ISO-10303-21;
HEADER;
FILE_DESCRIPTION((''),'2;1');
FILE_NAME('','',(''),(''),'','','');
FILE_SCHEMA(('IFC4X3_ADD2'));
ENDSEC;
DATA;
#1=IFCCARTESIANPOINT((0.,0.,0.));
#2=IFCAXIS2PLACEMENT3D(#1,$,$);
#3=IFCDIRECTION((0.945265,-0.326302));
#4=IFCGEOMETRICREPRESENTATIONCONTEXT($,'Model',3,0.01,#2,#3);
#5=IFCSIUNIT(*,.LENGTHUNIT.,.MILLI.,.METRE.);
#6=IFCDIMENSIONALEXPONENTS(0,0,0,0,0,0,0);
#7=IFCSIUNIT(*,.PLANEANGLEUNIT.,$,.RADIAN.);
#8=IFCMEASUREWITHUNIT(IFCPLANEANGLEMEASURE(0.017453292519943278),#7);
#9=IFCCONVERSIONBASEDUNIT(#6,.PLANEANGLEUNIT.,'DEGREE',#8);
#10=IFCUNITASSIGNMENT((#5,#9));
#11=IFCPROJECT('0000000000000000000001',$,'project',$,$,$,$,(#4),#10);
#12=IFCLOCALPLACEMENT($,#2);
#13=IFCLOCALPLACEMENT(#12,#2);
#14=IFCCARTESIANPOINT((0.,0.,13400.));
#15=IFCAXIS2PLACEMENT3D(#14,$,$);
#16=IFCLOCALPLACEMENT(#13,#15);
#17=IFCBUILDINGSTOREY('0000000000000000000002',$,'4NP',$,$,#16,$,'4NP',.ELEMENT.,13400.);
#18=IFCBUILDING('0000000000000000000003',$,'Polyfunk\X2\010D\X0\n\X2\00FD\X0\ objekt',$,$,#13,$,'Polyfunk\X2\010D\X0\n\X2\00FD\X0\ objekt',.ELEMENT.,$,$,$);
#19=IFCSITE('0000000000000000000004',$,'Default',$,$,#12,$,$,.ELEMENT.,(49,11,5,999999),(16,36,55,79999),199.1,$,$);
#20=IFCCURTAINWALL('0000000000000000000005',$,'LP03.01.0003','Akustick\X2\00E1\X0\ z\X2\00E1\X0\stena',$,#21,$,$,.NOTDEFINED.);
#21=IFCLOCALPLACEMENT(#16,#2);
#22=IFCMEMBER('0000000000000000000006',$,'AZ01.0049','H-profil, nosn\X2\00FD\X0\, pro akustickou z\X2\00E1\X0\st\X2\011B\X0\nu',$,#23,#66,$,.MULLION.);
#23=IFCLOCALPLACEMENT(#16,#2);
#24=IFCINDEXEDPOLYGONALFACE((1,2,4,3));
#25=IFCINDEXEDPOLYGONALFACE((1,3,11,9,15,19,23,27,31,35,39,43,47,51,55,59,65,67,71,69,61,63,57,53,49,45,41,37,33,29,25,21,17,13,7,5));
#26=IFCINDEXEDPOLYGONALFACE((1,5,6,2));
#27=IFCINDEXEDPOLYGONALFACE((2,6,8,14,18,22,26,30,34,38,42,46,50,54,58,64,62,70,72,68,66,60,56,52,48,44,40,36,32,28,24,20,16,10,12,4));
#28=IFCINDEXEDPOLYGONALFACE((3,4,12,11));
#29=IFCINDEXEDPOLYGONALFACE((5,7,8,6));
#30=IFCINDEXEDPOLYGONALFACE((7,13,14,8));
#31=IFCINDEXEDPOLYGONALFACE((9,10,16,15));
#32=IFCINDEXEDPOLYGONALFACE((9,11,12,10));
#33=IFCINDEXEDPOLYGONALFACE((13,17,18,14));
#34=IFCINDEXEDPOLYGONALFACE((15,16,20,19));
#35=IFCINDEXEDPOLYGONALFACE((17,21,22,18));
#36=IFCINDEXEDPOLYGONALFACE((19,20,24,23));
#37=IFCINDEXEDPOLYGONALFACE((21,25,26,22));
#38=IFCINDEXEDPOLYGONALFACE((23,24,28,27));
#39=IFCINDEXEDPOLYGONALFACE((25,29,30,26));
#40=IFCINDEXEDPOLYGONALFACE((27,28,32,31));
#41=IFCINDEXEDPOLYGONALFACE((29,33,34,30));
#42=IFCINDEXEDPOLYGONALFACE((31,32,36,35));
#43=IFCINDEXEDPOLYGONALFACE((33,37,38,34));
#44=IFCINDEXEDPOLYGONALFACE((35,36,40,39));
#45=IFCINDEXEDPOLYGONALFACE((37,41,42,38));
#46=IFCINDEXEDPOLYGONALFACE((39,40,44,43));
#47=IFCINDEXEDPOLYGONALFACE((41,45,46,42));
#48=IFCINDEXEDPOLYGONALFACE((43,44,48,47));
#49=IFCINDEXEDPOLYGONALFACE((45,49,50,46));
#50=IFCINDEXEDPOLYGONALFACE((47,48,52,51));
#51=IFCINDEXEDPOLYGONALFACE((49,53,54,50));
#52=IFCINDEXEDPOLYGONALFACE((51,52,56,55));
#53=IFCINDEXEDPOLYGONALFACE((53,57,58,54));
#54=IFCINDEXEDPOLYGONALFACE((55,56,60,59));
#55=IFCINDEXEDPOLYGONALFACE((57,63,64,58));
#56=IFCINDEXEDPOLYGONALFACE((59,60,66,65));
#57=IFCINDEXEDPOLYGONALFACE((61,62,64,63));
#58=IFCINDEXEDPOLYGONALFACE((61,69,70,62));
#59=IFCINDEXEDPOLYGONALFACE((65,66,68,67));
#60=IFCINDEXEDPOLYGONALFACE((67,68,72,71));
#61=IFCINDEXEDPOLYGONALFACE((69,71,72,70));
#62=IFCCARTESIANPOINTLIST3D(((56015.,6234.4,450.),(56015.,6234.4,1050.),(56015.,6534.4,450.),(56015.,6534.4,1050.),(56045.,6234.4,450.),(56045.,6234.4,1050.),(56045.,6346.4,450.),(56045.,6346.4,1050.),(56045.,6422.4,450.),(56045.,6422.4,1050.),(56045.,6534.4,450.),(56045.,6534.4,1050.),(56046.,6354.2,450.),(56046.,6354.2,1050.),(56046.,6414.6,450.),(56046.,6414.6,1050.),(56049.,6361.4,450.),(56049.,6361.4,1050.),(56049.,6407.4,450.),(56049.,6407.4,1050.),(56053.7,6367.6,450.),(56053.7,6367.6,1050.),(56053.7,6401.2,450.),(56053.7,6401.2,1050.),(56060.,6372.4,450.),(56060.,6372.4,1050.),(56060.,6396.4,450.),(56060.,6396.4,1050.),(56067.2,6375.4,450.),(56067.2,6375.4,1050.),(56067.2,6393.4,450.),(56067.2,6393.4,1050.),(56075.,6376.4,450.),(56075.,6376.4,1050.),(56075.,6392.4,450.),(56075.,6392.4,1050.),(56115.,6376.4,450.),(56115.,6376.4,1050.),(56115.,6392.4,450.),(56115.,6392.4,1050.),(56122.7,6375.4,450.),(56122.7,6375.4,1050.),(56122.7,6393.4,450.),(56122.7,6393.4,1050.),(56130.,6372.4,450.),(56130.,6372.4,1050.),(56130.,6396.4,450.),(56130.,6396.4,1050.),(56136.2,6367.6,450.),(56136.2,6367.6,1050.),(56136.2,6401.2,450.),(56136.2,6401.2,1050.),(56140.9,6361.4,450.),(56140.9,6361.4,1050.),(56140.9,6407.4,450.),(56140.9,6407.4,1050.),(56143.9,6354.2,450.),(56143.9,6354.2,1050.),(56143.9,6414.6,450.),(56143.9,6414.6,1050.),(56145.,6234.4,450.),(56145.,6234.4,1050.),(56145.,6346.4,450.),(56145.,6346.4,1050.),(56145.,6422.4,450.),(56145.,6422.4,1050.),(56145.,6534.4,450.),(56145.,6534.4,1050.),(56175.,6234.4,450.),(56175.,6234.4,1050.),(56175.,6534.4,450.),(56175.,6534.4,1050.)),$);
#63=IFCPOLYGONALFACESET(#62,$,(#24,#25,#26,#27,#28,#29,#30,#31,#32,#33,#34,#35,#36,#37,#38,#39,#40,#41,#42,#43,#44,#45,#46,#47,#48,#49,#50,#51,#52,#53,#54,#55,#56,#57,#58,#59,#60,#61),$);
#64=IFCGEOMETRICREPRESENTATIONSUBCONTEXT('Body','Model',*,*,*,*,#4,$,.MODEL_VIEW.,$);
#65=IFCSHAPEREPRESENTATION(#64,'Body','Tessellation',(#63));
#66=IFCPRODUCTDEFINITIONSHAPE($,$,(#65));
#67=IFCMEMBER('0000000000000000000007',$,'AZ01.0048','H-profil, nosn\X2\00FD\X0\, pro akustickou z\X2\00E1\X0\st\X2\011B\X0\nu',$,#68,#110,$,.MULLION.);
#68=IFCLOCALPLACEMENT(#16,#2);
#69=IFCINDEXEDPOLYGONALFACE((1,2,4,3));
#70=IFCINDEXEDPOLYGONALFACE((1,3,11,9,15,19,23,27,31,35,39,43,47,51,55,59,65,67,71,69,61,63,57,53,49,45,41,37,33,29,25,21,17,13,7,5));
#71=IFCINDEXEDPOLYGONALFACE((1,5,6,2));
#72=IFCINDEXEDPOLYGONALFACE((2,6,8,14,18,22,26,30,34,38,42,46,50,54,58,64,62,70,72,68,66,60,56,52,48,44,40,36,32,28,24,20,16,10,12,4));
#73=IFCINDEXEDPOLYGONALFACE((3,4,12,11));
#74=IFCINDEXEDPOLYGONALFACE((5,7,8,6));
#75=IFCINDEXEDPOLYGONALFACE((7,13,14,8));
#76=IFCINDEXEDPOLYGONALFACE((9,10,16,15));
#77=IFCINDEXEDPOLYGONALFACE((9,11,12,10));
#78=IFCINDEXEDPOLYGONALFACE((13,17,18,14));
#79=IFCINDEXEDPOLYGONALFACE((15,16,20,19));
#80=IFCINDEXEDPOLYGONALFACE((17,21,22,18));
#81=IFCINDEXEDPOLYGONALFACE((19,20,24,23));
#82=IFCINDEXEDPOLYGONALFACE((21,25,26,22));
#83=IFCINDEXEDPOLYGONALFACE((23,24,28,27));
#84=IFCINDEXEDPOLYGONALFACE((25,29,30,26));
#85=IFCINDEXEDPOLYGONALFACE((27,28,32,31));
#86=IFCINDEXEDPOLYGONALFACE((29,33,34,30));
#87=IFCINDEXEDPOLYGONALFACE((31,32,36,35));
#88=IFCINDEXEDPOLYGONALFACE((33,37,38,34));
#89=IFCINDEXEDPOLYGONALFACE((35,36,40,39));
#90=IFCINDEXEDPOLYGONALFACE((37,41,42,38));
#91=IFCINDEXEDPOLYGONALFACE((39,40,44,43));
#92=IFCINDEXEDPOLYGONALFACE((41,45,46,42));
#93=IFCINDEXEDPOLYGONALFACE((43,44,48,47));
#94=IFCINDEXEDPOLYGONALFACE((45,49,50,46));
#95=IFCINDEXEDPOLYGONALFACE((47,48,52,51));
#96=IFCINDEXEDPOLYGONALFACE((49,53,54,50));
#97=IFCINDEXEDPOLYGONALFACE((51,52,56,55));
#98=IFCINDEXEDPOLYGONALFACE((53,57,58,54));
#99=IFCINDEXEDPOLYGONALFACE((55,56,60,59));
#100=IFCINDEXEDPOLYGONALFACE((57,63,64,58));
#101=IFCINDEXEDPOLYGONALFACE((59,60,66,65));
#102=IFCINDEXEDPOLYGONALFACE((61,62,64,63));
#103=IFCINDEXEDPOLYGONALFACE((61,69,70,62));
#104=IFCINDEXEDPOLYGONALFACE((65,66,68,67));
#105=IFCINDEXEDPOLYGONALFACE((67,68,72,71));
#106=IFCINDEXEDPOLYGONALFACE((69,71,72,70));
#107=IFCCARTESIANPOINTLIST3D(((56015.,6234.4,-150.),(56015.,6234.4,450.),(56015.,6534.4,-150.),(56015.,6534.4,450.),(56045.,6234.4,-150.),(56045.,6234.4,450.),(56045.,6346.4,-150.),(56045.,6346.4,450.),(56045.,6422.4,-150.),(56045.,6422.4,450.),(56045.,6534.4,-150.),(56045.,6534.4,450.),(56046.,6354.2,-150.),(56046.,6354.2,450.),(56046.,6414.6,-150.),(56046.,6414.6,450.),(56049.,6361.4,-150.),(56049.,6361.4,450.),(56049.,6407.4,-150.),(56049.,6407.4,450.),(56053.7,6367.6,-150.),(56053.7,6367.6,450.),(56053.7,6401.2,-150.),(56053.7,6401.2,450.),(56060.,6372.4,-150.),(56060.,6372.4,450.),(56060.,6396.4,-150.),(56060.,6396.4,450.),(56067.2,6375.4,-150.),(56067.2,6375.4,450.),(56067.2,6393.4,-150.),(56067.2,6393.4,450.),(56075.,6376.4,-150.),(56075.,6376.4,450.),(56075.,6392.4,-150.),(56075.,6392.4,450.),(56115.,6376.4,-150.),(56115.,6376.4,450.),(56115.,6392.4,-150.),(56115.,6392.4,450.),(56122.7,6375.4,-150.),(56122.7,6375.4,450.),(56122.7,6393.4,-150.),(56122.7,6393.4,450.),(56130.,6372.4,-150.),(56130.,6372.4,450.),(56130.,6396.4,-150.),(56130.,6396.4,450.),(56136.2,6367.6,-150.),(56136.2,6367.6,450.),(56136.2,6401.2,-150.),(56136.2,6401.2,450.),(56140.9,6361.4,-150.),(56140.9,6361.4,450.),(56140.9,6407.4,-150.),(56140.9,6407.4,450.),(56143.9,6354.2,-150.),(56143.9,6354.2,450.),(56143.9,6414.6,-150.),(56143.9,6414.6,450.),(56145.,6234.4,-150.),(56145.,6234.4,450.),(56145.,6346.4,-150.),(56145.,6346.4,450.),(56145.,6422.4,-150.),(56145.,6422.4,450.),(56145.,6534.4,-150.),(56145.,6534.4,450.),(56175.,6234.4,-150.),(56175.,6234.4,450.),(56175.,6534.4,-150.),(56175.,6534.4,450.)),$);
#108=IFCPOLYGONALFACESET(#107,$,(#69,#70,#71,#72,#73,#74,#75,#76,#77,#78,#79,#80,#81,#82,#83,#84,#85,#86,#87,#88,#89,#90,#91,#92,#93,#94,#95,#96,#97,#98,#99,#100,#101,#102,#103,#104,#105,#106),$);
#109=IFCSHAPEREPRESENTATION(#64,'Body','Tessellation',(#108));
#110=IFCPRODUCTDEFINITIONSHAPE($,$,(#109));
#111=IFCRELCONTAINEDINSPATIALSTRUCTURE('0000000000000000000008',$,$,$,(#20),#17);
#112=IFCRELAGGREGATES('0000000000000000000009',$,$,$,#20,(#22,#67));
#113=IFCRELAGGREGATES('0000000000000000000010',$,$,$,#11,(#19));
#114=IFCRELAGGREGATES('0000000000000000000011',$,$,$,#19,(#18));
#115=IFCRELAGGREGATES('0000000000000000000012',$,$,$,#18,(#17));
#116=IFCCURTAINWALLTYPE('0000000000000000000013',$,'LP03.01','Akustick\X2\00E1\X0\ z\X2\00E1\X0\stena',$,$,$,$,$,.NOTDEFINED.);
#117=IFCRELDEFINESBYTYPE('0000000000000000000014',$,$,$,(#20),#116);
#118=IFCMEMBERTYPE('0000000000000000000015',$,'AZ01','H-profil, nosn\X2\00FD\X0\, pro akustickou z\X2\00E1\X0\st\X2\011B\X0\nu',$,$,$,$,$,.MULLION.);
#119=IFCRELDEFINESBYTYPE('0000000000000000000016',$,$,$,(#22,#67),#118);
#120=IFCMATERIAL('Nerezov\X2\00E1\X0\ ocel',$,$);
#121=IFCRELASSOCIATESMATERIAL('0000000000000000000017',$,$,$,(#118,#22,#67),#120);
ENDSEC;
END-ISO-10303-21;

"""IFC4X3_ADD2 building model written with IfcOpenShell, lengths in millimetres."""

from ifc_helpers import new_model, entity, si_unit, converted_unit, direction, frame, frame_2d, origin, place, context, subcontext, project, spatial, polyline, circle_curve, parameter, trimmed, segment, composite_curve, outline, extrude, source, transform, mapped, material, material_profile, profile_set, profile_usage, type_object, element, aggregate, save


model = new_model("IFC4X3_ADD2")

# Units and contexts
model_context = context("Model", 3, precision=0.01, world=origin(), true_north=direction((0.945265, -0.326302)))
body_context = subcontext(model_context, "Body", "Model", "MODEL_VIEW")
ifc_project = project(units=[si_unit("LENGTHUNIT", "METRE", prefix="MILLI"), converted_unit("PLANEANGLEUNIT", "DEGREE", entity("IfcPlaneAngleMeasure", 0.017453292519943278), si_unit("PLANEANGLEUNIT", "RADIAN"), dimensions=[0, 0, 0, 0, 0, 0, 0])], contexts=[model_context])

# Site, building, storey
site_placement = place(None, origin())
site = spatial("IfcSite", under=ifc_project, at=site_placement, Name="Default", CompositionType="ELEMENT", RefLatitude=(49, 11, 5, 999999), RefLongitude=(16, 36, 55, 79999), RefElevation=199.1)
building_placement = place(site_placement, origin())
building = spatial("IfcBuilding", under=site, at=building_placement, Name="Polyfunkčný objekt", LongName="Polyfunkčný objekt", CompositionType="ELEMENT")
storey_placement = place(building_placement, frame((0.0, 0.0, 13400.0)))
storey = spatial("IfcBuildingStorey", under=building, at=storey_placement, Name="4NP", LongName="4NP", CompositionType="ELEMENT", Elevation=13400.0)

# Shared definitions
curtain_wall_type = type_object("IfcCurtainWallType", Name="LP03.01", Description="Akustická zástena", PredefinedType="NOTDEFINED")
ifc_material_1 = material(Name="Nerezová ocel")
ifc_material_profile = material_profile(ifc_material_1, outline(composite_curve([segment(polyline([(50.0, -150.0), (80.0, -150.0)]), True, "CONTINUOUS"), segment(polyline([(80.0, -150.0), (80.0, 150.0)]), True, "CONTINUOUS"), segment(polyline([(80.0, 150.0), (50.0, 150.0)]), True, "CONTINUOUS"), segment(polyline([(50.0, 150.0), (50.0, 38.0)]), True, "CONTINUOUS"), segment(trimmed(circle_curve(frame_2d((20.0, 38.0), x_axis=(0.0, 1.0)), 30.0), [parameter(180.0)], [parameter(270.0)], True, "PARAMETER"), False, "CONTINUOUS"), segment(polyline([(20.0, 8.0), (-20.0, 8.0)]), True, "CONTINUOUS"), segment(trimmed(circle_curve(frame_2d((-20.0, 38.0), x_axis=(0.0, 1.0)), 30.0), [parameter(90.0)], [parameter(180.0)], True, "PARAMETER"), False, "CONTINUOUS"), segment(polyline([(-50.0, 38.0), (-50.0, 150.0)]), True, "CONTINUOUS"), segment(polyline([(-50.0, 150.0), (-80.0, 150.0)]), True, "CONTINUOUS"), segment(polyline([(-80.0, 150.0), (-80.0, -150.0)]), True, "CONTINUOUS"), segment(polyline([(-80.0, -150.0), (-50.0, -150.0)]), True, "CONTINUOUS"), segment(polyline([(-50.0, -150.0), (-50.0, -38.0)]), True, "CONTINUOUS"), segment(trimmed(circle_curve(frame_2d((-20.0, -38.0), x_axis=(0.0, 1.0)), 30.0), [parameter(0.0)], [parameter(90.0)], True, "PARAMETER"), False, "CONTINUOUS"), segment(polyline([(-20.0, -8.0), (20.0, -8.0)]), True, "CONTINUOUS"), segment(trimmed(circle_curve(frame_2d((20.0, -38.0), x_axis=(0.0, 1.0)), 30.0), [parameter(270.0)], [parameter(0.0)], True, "PARAMETER"), False, "CONTINUOUS"), segment(polyline([(50.0, -38.0), (50.0, -150.0)]), True, "CONTINUOUS")], self_intersect=False)), Name="Profil zástena")
ifc_profile_set = profile_set([ifc_material_profile], Name="Profil zástena")
ifc_profile_usage = profile_usage(ifc_profile_set)
member_type = type_object("IfcMemberType", Name="AZ01", Description="H-profil, nosný, pro akustickou zástěnu", PredefinedType="MULLION", material=ifc_profile_set)

# Curtain wall, members
curtain_wall_1_placement = place(storey_placement, frame((0.0, 0.0, -13400.0)))
curtain_wall_1 = element("IfcCurtainWall", 1, at=curtain_wall_1_placement, inside=storey, type_object=curtain_wall_type, Name="LP03.01.0003", Description="Akustická zástena", PredefinedType="NOTDEFINED")
shared_shape_1 = source(origin(), body_context, "Body", "SweptSolid", [
    extrude(outline(composite_curve([segment(polyline([(-150.0, -50.0), (-150.0, -80.0)]), True, "CONTINUOUS"), segment(polyline([(-150.0, -80.0), (150.0, -80.0)]), True, "CONTINUOUS"), segment(polyline([(150.0, -80.0), (150.0, -50.0)]), True, "CONTINUOUS"), segment(polyline([(150.0, -50.0), (38.0, -50.0)]), True, "CONTINUOUS"), segment(trimmed(circle_curve(frame_2d((38.0, -20.0), x_axis=(1.0, 0.0)), 30.0), [parameter(180.0)], [parameter(270.0)], True, "PARAMETER"), False, "CONTINUOUS"), segment(polyline([(8.0, -20.0), (8.0, 20.0)]), True, "CONTINUOUS"), segment(trimmed(circle_curve(frame_2d((38.0, 20.0), x_axis=(1.0, 0.0)), 30.0), [parameter(90.0)], [parameter(180.0)], True, "PARAMETER"), False, "CONTINUOUS"), segment(polyline([(38.0, 50.0), (150.0, 50.0)]), True, "CONTINUOUS"), segment(polyline([(150.0, 50.0), (150.0, 80.0)]), True, "CONTINUOUS"), segment(polyline([(150.0, 80.0), (-150.0, 80.0)]), True, "CONTINUOUS"), segment(polyline([(-150.0, 80.0), (-150.0, 50.0)]), True, "CONTINUOUS"), segment(polyline([(-150.0, 50.0), (-38.0, 50.0)]), True, "CONTINUOUS"), segment(trimmed(circle_curve(frame_2d((-38.0, 20.0), x_axis=(1.0, 0.0)), 30.0), [parameter(0.0)], [parameter(90.0)], True, "PARAMETER"), False, "CONTINUOUS"), segment(polyline([(-8.0, 20.0), (-8.0, -20.0)]), True, "CONTINUOUS"), segment(trimmed(circle_curve(frame_2d((-38.0, -20.0), x_axis=(1.0, 0.0)), 30.0), [parameter(270.0)], [parameter(0.0)], True, "PARAMETER"), False, "CONTINUOUS"), segment(polyline([(-38.0, -50.0), (-150.0, -50.0)]), True, "CONTINUOUS")], self_intersect=False)), frame((-150.0, 0.0, -600.0), z_axis=(0.0, 0.0, -1.0), x_axis=(1.0, 0.0, 0.0)), (0.0, 0.0, -1.0), 600.0),
])
member_1_placement = place(curtain_wall_1_placement, frame((56095.0, 6534.4, 13850.0), z_axis=(0.0, 0.0, -1.0), x_axis=(0.0, 1.0, 0.0)))
member_1 = element("IfcMember", 2, at=member_1_placement, type_object=member_type, material=ifc_profile_usage, Name="AZ01.0049", Description="H-profil, nosný, pro akustickou zástěnu", PredefinedType="MULLION", context=body_context, shape_type="MappedRepresentation", body=[
    mapped(shared_shape_1, transform((0.0, 0.0, 0.0), scale=1.0)),
])
shared_shape_2 = source(origin(), body_context, "Body", "SweptSolid", [
    extrude(outline(composite_curve([segment(polyline([(-150.0, -50.0), (-150.0, -80.0)]), True, "CONTINUOUS"), segment(polyline([(-150.0, -80.0), (150.0, -80.0)]), True, "CONTINUOUS"), segment(polyline([(150.0, -80.0), (150.0, -50.0)]), True, "CONTINUOUS"), segment(polyline([(150.0, -50.0), (38.0, -50.0)]), True, "CONTINUOUS"), segment(trimmed(circle_curve(frame_2d((38.0, -20.0), x_axis=(1.0, 0.0)), 30.0), [parameter(180.0)], [parameter(270.0)], True, "PARAMETER"), False, "CONTINUOUS"), segment(polyline([(8.0, -20.0), (8.0, 20.0)]), True, "CONTINUOUS"), segment(trimmed(circle_curve(frame_2d((38.0, 20.0), x_axis=(1.0, 0.0)), 30.0), [parameter(90.0)], [parameter(180.0)], True, "PARAMETER"), False, "CONTINUOUS"), segment(polyline([(38.0, 50.0), (150.0, 50.0)]), True, "CONTINUOUS"), segment(polyline([(150.0, 50.0), (150.0, 80.0)]), True, "CONTINUOUS"), segment(polyline([(150.0, 80.0), (-150.0, 80.0)]), True, "CONTINUOUS"), segment(polyline([(-150.0, 80.0), (-150.0, 50.0)]), True, "CONTINUOUS"), segment(polyline([(-150.0, 50.0), (-38.0, 50.0)]), True, "CONTINUOUS"), segment(trimmed(circle_curve(frame_2d((-38.0, 20.0), x_axis=(1.0, 0.0)), 30.0), [parameter(0.0)], [parameter(90.0)], True, "PARAMETER"), False, "CONTINUOUS"), segment(polyline([(-8.0, 20.0), (-8.0, -20.0)]), True, "CONTINUOUS"), segment(trimmed(circle_curve(frame_2d((-38.0, -20.0), x_axis=(1.0, 0.0)), 30.0), [parameter(270.0)], [parameter(0.0)], True, "PARAMETER"), False, "CONTINUOUS"), segment(polyline([(-38.0, -50.0), (-150.0, -50.0)]), True, "CONTINUOUS")], self_intersect=False)), frame((-150.0, 0.0, -600.0), z_axis=(0.0, 0.0, -1.0), x_axis=(1.0, 0.0, 0.0)), (0.0, 0.0, -1.0), 600.0),
])
member_2_placement = place(curtain_wall_1_placement, frame((56095.0, 6534.4, 13250.0), z_axis=(0.0, 0.0, -1.0), x_axis=(0.0, 1.0, 0.0)))
member_2 = element("IfcMember", 3, at=member_2_placement, type_object=member_type, material=ifc_profile_usage, Name="AZ01.0048", Description="H-profil, nosný, pro akustickou zástěnu", PredefinedType="MULLION", context=body_context, shape_type="MappedRepresentation", body=[
    mapped(shared_shape_2, transform((0.0, 0.0, 0.0), scale=1.0)),
])
aggregate(curtain_wall_1, [member_1, member_2])

save(model, "model.ifc")
